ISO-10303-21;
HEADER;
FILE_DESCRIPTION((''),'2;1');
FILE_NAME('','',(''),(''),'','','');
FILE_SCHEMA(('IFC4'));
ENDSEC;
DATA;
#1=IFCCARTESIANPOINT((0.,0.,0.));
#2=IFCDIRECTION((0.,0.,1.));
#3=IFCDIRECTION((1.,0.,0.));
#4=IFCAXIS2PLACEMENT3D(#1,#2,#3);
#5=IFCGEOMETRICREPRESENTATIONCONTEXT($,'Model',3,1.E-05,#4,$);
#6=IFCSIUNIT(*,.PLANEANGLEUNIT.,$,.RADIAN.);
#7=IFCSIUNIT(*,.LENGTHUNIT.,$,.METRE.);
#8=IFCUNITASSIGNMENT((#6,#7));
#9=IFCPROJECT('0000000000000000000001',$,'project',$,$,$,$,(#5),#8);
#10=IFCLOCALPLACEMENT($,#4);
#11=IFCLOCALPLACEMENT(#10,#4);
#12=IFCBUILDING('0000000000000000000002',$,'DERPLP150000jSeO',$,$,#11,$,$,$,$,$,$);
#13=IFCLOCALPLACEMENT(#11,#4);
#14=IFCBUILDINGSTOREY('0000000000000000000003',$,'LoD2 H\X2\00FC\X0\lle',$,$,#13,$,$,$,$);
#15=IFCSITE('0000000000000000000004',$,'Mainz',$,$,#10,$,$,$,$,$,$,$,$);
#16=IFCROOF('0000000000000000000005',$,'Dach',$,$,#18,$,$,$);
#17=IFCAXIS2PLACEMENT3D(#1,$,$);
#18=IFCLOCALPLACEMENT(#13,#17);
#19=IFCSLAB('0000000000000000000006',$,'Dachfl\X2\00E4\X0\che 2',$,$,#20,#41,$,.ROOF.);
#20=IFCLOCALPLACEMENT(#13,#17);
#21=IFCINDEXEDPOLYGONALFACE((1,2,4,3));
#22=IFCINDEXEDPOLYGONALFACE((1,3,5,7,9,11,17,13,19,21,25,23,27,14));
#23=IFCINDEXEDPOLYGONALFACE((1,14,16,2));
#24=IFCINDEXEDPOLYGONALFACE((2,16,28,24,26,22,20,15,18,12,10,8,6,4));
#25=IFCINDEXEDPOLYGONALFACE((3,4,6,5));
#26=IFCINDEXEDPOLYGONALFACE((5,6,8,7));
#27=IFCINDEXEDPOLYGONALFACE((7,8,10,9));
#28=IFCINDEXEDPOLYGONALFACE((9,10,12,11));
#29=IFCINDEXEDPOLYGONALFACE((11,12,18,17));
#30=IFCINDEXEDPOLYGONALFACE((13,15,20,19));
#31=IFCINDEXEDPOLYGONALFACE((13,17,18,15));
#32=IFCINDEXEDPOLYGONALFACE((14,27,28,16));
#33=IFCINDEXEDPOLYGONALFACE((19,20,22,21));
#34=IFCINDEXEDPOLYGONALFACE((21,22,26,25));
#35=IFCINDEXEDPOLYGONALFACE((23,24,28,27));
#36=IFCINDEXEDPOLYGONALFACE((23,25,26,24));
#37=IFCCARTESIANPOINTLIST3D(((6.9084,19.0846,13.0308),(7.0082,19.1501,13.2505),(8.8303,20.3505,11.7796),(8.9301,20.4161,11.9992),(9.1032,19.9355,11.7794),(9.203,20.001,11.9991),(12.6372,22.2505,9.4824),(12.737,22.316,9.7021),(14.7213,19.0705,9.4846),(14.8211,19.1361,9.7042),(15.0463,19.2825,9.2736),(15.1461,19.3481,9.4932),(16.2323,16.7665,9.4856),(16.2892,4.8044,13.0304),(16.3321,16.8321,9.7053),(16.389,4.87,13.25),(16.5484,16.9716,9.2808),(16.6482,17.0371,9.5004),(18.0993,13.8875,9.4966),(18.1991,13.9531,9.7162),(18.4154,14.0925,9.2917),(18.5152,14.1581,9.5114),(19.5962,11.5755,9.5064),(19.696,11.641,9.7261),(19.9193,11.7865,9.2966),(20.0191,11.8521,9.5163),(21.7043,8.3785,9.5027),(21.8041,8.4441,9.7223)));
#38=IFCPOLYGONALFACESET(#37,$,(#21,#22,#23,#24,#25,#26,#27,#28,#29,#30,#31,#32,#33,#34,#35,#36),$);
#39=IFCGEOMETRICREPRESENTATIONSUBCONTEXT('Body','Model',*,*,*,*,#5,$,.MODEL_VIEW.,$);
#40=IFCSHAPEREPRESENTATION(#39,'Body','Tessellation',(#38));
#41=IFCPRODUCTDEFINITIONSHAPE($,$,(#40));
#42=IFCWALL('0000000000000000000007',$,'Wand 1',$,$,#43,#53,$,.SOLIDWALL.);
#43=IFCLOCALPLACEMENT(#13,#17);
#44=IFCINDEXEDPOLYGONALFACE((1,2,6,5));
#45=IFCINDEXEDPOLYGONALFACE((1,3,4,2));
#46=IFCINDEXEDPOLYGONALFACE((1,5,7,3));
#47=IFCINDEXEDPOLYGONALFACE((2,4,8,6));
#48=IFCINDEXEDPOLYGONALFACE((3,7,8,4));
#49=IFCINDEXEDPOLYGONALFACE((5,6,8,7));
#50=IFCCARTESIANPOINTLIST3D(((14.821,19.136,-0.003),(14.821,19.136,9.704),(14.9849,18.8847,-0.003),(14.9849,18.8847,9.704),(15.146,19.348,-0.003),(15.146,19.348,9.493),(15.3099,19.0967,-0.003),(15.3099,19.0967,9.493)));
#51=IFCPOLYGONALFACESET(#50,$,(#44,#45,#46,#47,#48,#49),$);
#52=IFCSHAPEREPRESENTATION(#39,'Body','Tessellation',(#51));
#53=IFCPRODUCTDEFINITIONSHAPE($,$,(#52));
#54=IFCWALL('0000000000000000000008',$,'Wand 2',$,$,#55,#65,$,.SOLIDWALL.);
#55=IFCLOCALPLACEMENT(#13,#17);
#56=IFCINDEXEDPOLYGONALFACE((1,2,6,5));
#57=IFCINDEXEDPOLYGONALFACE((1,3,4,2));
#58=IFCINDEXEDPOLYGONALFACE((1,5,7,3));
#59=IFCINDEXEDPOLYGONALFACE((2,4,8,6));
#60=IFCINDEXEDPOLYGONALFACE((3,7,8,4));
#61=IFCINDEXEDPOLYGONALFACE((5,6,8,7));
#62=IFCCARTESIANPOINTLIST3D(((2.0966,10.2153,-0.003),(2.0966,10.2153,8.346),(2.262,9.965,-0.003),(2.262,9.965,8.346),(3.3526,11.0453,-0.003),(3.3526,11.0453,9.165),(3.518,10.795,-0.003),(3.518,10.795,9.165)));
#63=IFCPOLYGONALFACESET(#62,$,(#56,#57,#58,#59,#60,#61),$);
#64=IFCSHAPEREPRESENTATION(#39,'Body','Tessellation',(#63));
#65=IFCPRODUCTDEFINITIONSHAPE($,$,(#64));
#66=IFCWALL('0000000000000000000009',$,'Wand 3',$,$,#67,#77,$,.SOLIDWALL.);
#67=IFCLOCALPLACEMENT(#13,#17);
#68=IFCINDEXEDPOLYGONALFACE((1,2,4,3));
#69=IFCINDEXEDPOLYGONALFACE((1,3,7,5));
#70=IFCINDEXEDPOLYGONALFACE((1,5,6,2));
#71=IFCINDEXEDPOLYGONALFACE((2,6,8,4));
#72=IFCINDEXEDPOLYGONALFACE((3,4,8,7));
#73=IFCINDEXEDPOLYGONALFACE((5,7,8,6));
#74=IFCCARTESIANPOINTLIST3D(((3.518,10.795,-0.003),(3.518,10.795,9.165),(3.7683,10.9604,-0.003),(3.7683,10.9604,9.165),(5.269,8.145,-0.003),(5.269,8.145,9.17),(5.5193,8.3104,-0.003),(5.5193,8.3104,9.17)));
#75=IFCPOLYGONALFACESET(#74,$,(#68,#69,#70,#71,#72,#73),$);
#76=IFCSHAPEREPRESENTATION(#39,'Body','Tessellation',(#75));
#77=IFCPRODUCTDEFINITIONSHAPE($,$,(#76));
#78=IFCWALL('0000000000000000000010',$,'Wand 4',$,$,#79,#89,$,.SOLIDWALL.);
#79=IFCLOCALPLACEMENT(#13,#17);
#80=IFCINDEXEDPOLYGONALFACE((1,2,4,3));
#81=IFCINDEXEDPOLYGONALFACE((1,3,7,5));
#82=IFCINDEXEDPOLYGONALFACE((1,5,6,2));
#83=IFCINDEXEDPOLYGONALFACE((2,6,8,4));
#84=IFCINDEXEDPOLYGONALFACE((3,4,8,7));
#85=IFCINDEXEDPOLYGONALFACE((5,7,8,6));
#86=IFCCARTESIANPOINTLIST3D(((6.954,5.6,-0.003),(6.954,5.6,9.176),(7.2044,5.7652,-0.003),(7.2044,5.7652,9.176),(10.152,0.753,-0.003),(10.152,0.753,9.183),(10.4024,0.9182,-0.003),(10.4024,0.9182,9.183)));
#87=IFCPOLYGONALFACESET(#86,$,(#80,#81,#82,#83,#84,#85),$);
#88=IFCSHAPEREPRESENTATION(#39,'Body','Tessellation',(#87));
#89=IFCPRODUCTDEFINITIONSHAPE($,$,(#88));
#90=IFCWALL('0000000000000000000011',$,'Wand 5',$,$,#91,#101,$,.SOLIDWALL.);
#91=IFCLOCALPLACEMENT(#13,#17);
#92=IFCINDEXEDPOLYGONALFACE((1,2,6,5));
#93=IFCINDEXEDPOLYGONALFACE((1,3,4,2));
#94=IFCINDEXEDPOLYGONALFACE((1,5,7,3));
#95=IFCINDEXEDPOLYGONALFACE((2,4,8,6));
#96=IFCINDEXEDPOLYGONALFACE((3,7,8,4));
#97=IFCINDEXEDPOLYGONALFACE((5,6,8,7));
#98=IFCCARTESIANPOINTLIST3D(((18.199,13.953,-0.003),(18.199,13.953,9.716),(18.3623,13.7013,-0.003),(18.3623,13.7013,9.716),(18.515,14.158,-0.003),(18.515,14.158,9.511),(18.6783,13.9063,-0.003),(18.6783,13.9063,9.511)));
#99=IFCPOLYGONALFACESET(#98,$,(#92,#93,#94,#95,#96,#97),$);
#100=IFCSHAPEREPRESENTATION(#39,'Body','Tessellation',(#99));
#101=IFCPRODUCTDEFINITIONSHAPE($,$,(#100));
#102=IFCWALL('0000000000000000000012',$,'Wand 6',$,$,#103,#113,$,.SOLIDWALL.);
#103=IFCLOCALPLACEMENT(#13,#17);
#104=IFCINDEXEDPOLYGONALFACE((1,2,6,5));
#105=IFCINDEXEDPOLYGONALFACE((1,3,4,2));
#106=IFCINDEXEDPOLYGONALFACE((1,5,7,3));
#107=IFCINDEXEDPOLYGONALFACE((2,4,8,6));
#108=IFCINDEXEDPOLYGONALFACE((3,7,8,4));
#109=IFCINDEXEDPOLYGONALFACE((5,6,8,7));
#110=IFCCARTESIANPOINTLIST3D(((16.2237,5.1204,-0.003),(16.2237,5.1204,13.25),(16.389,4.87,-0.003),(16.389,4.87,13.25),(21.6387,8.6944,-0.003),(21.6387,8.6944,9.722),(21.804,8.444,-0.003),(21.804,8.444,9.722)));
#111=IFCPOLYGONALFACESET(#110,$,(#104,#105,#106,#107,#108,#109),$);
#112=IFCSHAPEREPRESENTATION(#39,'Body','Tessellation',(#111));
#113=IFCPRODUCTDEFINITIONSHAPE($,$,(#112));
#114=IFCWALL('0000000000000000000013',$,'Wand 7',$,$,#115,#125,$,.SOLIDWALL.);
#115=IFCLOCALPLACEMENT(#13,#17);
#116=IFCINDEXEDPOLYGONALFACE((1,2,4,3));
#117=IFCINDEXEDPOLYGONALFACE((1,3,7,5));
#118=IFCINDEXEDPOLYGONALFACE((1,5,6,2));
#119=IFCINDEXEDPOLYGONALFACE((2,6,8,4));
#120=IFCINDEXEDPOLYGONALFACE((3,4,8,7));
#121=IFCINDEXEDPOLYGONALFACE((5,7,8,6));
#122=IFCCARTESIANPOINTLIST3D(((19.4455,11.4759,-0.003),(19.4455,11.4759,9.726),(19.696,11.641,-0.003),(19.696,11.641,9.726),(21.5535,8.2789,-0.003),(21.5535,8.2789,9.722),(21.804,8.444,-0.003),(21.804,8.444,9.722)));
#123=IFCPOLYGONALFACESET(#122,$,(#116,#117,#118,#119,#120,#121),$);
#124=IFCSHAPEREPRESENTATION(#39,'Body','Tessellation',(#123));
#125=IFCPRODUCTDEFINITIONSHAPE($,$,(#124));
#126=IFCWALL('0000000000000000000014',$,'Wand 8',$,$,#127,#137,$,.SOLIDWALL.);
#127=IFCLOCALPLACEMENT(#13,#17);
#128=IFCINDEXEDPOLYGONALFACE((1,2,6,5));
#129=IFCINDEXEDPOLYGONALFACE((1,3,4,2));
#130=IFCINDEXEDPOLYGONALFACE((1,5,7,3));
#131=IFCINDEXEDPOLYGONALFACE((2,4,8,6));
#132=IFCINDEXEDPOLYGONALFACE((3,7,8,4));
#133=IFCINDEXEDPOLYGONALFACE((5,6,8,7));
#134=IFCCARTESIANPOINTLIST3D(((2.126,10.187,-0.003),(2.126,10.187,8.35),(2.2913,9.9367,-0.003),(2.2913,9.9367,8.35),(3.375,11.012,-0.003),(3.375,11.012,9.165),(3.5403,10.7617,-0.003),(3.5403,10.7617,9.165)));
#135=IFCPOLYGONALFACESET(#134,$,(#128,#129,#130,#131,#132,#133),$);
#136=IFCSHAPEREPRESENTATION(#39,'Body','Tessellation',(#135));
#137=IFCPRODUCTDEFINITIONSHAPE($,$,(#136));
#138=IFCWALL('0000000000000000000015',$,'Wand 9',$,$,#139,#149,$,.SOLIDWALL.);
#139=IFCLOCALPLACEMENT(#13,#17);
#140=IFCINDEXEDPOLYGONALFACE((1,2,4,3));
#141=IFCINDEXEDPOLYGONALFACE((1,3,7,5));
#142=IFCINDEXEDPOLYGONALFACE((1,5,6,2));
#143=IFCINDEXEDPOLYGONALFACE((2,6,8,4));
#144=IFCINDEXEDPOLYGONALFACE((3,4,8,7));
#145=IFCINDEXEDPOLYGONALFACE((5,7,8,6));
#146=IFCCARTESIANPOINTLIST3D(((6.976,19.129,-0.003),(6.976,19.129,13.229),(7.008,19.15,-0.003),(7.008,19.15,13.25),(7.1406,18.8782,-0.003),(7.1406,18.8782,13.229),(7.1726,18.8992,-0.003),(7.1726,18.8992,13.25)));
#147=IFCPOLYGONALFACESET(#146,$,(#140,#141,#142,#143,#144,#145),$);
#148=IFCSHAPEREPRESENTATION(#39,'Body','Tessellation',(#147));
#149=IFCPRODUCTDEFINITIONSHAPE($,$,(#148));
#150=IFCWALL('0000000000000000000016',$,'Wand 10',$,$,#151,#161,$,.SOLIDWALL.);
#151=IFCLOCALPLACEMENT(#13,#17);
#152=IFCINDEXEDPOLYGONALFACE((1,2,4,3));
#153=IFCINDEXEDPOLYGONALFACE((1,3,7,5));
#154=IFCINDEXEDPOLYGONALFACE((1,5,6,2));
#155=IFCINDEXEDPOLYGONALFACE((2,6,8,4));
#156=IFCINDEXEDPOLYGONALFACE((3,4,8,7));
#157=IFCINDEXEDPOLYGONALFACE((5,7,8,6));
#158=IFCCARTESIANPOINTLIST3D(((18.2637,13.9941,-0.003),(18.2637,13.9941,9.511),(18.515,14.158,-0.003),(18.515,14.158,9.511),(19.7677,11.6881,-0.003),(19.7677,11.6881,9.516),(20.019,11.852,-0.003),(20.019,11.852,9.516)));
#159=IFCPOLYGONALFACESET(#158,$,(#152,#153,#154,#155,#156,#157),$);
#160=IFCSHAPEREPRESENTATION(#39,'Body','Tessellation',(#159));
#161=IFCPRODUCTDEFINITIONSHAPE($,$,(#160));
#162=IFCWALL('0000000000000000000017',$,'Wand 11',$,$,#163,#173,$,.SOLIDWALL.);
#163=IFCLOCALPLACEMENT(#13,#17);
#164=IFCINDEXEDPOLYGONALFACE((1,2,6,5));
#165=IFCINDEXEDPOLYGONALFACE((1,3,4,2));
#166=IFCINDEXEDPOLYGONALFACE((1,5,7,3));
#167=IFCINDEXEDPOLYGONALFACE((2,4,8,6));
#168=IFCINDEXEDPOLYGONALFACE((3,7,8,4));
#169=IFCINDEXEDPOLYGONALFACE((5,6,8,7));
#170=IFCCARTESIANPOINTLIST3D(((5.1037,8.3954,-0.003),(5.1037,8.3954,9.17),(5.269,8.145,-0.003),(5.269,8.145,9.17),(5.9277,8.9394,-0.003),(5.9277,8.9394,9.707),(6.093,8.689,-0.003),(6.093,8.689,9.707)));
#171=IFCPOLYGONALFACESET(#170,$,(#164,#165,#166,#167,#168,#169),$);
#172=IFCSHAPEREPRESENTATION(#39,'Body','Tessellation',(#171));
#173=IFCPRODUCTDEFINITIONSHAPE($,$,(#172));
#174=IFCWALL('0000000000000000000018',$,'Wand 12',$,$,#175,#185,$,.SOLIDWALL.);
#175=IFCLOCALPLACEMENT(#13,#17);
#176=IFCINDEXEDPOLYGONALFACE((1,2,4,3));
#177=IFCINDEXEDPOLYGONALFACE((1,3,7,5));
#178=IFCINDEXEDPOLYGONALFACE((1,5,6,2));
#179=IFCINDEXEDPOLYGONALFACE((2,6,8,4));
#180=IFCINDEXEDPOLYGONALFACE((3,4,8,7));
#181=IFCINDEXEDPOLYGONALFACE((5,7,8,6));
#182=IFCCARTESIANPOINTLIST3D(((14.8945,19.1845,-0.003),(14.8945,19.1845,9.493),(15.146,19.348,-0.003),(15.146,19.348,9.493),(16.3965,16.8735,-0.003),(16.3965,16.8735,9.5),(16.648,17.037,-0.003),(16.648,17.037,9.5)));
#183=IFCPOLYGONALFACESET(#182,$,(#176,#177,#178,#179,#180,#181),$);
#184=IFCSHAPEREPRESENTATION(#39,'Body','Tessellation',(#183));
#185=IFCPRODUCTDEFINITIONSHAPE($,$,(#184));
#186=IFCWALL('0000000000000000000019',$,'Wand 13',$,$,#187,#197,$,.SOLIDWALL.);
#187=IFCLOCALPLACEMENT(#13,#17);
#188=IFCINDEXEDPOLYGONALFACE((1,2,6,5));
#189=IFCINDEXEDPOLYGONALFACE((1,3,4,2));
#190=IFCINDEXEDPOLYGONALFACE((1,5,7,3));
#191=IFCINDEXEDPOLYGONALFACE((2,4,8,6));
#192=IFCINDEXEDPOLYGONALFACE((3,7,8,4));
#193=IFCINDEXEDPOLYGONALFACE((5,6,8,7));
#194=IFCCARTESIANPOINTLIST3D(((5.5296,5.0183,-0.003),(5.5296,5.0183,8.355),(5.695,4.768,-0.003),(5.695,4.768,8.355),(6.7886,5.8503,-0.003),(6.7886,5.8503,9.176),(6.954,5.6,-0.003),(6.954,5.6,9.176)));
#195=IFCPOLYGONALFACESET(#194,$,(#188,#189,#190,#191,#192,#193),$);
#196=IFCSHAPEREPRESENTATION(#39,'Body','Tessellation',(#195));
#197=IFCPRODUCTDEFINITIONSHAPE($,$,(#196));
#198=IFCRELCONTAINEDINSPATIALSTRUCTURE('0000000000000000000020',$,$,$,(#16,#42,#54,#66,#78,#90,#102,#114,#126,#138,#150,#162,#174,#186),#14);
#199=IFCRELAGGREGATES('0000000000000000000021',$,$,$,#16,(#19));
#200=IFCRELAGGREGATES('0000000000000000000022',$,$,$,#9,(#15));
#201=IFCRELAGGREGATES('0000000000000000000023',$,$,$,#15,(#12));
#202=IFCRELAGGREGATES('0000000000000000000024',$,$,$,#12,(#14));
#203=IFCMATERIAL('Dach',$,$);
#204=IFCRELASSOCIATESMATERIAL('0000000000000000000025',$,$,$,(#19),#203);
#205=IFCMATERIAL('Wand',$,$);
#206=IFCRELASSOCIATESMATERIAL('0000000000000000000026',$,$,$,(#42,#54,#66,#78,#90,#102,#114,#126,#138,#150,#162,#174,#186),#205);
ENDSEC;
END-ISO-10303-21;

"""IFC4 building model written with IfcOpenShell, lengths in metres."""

from ifc_helpers import new_model, si_unit, frame, origin_with_axes, place, context, subcontext, project, spatial, polyline, outline, extrude, material, element, aggregate, save


model = new_model("IFC4")

# Units and contexts
model_context = context("Model", 3, precision=1e-05, world=origin_with_axes())
body_context = subcontext(model_context, "Body", "Model", "MODEL_VIEW")
ifc_project = project(units=[si_unit("PLANEANGLEUNIT", "RADIAN"), si_unit("LENGTHUNIT", "METRE")], contexts=[model_context])

# Site, building, storey
site_placement = place(None, origin_with_axes())
site = spatial("IfcSite", under=ifc_project, at=site_placement, Name="Mainz")
building_placement = place(site_placement, origin_with_axes())
building = spatial("IfcBuilding", under=site, at=building_placement, Name="DERPLP150000jSeO")
storey_placement = place(building_placement, origin_with_axes())
storey = spatial("IfcBuildingStorey", under=building, at=storey_placement, Name="LoD2 Hülle")

# Roof, slab
roof_placement = place(storey_placement, origin_with_axes())
roof = element("IfcRoof", 1, at=roof_placement, inside=storey, Name="Dach")
ifc_material_1 = material(Name="Dach")
slab_1_placement = place(roof_placement, origin_with_axes())
slab_1 = element("IfcSlab", 2, at=slab_1_placement, material=ifc_material_1, Name="Dachfläche 2", PredefinedType="ROOF", context=body_context, shape_type="SweptSolid", body=[
    extrude(outline(polyline([(0.0, 0.0), (7.3853, 0.0), (7.3849, 3.8294), (7.8242, 3.8276), (7.8397, 6.5807), (7.4109, 6.5837), (7.4405, 10.0149), (7.8693, 10.0119), (7.8898, 12.7681), (7.4481, 12.7702), (7.4599, 16.5722), (2.6512, 16.5868), (2.6518, 17.0835), (0.0323, 17.0857), (0.0, 0.0)])), frame((16.389, 4.87, 13.25), z_axis=(0.399241, 0.262238, 0.878543), x_axis=(0.733234, 0.483948, -0.477663)), (0.0, 0.0, -1.0), 0.25),
])
aggregate(roof, [slab_1])

# Walls
ifc_material_2 = material(Name="Wand")
wall_1_placement = place(storey_placement, origin_with_axes())
element("IfcWall", 3, at=wall_1_placement, inside=storey, material=ifc_material_2, Name="Wand 1", PredefinedType="SOLIDWALL", context=body_context, shape_type="SweptSolid", body=[
    extrude(outline(polyline([(0.0, 0.0), (0.4417, 0.0), (4.978, 8.3424), (4.6371, 8.5278), (0.0, 0.0)])), frame((14.821, 19.136, 9.704), z_axis=(-0.546346, 0.837559, 0.0), x_axis=(0.73581, 0.479975, -0.477711)), (0.0, 0.0, -1.0), 0.3),
])
wall_2_placement = place(storey_placement, origin_with_axes())
element("IfcWall", 4, at=wall_2_placement, inside=storey, material=ifc_material_2, Name="Wand 2", PredefinedType="SOLIDWALL", context=body_context, shape_type="SweptSolid", body=[
    extrude(outline(polyline([(0.0, 0.0), (1.7138, 0.0), (5.7036, 7.334), (4.3812, 8.0534), (0.0, 0.0)])), frame((3.518, 10.795, 9.165), z_axis=(0.551323, -0.834292, 0.0), x_axis=(-0.732864, -0.484297, -0.477878)), (0.0, 0.0, -1.0), 0.3),
])
wall_3_placement = place(storey_placement, origin_with_axes())
element("IfcWall", 5, at=wall_3_placement, inside=storey, material=ifc_material_2, Name="Wand 3", PredefinedType="SOLIDWALL", context=body_context, shape_type="SweptSolid", body=[
    extrude(outline(polyline([(0.0, 0.0), (3.1762, 0.0), (3.1907, 9.168), (0.0144, 9.173), (0.0, 0.0)])), frame((5.269, 8.145, 9.17), z_axis=(-0.83432, -0.551281, 0.0), x_axis=(-0.55128, 0.834319, -0.001574)), (0.0, 0.0, -1.0), 0.3),
])
wall_4_placement = place(storey_placement, origin_with_axes())
element("IfcWall", 6, at=wall_4_placement, inside=storey, material=ifc_material_2, Name="Wand 4", PredefinedType="SOLIDWALL", context=body_context, shape_type="SweptSolid", body=[
    extrude(outline(polyline([(0.0, 0.0), (5.8069, 0.0), (5.818, 9.179), (0.0111, 9.186), (0.0, 0.0)])), frame((10.152, 0.753, 9.183), z_axis=(-0.83469, -0.55072, 0.0), x_axis=(-0.550719, 0.83469, -0.001205)), (0.0, 0.0, -1.0), 0.3),
])
wall_5_placement = place(storey_placement, origin_with_axes())
element("IfcWall", 7, at=wall_5_placement, inside=storey, material=ifc_material_2, Name="Wand 5", PredefinedType="SOLIDWALL", context=body_context, shape_type="SweptSolid", body=[
    extrude(outline(polyline([(0.0, 0.0), (0.4288, 0.0), (4.9768, 8.3566), (4.646, 8.5366), (0.0, 0.0)])), frame((18.199, 13.953, 9.716), z_axis=(-0.544242, 0.838929, 0.0), x_axis=(0.736867, 0.478031, -0.478031)), (0.0, 0.0, -1.0), 0.3),
])
wall_6_placement = place(storey_placement, origin_with_axes())
element("IfcWall", 8, at=wall_6_placement, inside=storey, material=ifc_material_2, Name="Wand 6", PredefinedType="SOLIDWALL", context=body_context, shape_type="SweptSolid", body=[
    extrude(outline(polyline([(0.0, 0.0), (7.3853, 0.0), (1.0542, 11.643), (-4.6457, 8.5436), (0.0, 0.0)])), frame((21.804, 8.444, 9.722), z_axis=(0.550853, -0.834602, 0.0), x_axis=(-0.733214, -0.483935, 0.477706)), (0.0, 0.0, -1.0), 0.3),
])
wall_7_placement = place(storey_placement, origin_with_axes())
element("IfcWall", 9, at=wall_7_placement, inside=storey, material=ifc_material_2, Name="Wand 7", PredefinedType="SOLIDWALL", context=body_context, shape_type="SweptSolid", body=[
    extrude(outline(polyline([(0.0, 0.0), (3.8294, 0.0), (3.8396, 9.725), (0.0102, 9.729), (0.0, 0.0)])), frame((19.696, 11.641, 9.726), z_axis=(0.834852, 0.550475, 0.0), x_axis=(0.550474, -0.834851, -0.001045)), (0.0, 0.0, -1.0), 0.3),
])
wall_8_placement = place(storey_placement, origin_with_axes())
element("IfcWall", 10, at=wall_8_placement, inside=storey, material=ifc_material_2, Name="Wand 8", PredefinedType="SOLIDWALL", context=body_context, shape_type="SweptSolid", body=[
    extrude(outline(polyline([(0.0, 0.0), (1.7044, 0.0), (-2.6796, 8.0519), (-3.9943, 7.3361), (0.0, 0.0)])), frame((2.126, 10.187, 8.35), z_axis=(-0.551149, 0.834407, 0.0), x_axis=(0.732825, 0.484052, 0.478185)), (0.0, 0.0, -1.0), 0.3),
])
wall_9_placement = place(storey_placement, origin_with_axes())
element("IfcWall", 11, at=wall_9_placement, inside=storey, material=ifc_material_2, Name="Wand 9", PredefinedType="SOLIDWALL", context=body_context, shape_type="SweptSolid", body=[
    extrude(outline(polyline([(0.0, 0.0), (0.0437, 0.0), (-6.3312, 11.6191), (-6.3648, 11.6007), (0.0, 0.0)])), frame((6.976, 19.129, 13.229), z_axis=(-0.548656, 0.836048, 0.0), x_axis=(0.732974, 0.481014, 0.481014)), (0.0, 0.0, -1.0), 0.3),
])
wall_10_placement = place(storey_placement, origin_with_axes())
element("IfcWall", 12, at=wall_10_placement, inside=storey, material=ifc_material_2, Name="Wand 10", PredefinedType="SOLIDWALL", context=body_context, shape_type="SweptSolid", body=[
    extrude(outline(polyline([(0.0, 0.0), (2.7531, 0.0), (2.7358, 9.519), (-0.0173, 9.514), (0.0, 0.0)])), frame((18.515, 14.158, 9.511), z_axis=(0.837596, 0.54629, 0.0), x_axis=(0.546289, -0.837595, 0.001816)), (0.0, 0.0, -1.0), 0.3),
])
wall_11_placement = place(storey_placement, origin_with_axes())
element("IfcWall", 13, at=wall_11_placement, inside=storey, material=ifc_material_2, Name="Wand 11", PredefinedType="SOLIDWALL", context=body_context, shape_type="SweptSolid", body=[
    extrude(outline(polyline([(0.0, 0.0), (1.124, 0.0), (5.5066, 8.0583), (4.6392, 8.5301), (0.0, 0.0)])), frame((6.093, 8.689, 9.707), z_axis=(0.550955, -0.834535, 0.0), x_axis=(-0.733124, -0.484004, -0.477776)), (0.0, 0.0, -1.0), 0.3),
])
wall_12_placement = place(storey_placement, origin_with_axes())
element("IfcWall", 14, at=wall_12_placement, inside=storey, material=ifc_material_2, Name="Wand 12", PredefinedType="SOLIDWALL", context=body_context, shape_type="SweptSolid", body=[
    extrude(outline(polyline([(0.0, 0.0), (2.7562, 0.0), (2.7321, 9.503), (-0.0241, 9.496), (0.0, 0.0)])), frame((15.146, 19.348, 9.493), z_axis=(0.838468, 0.54495, 0.0), x_axis=(0.544948, -0.838466, 0.00254)), (0.0, 0.0, -1.0), 0.3),
])
wall_13_placement = place(storey_placement, origin_with_axes())
element("IfcWall", 15, at=wall_13_placement, inside=storey, material=ifc_material_2, Name="Wand 13", PredefinedType="SOLIDWALL", context=body_context, shape_type="SweptSolid", body=[
    extrude(outline(polyline([(0.0, 0.0), (1.7179, 0.0), (5.7122, 7.3418), (4.3866, 8.063), (0.0, 0.0)])), frame((6.954, 5.6, 9.176), z_axis=(0.551331, -0.834286, 0.0), x_axis=(-0.732851, -0.484299, -0.477896)), (0.0, 0.0, -1.0), 0.3),
])

save(model, "model.ifc")
